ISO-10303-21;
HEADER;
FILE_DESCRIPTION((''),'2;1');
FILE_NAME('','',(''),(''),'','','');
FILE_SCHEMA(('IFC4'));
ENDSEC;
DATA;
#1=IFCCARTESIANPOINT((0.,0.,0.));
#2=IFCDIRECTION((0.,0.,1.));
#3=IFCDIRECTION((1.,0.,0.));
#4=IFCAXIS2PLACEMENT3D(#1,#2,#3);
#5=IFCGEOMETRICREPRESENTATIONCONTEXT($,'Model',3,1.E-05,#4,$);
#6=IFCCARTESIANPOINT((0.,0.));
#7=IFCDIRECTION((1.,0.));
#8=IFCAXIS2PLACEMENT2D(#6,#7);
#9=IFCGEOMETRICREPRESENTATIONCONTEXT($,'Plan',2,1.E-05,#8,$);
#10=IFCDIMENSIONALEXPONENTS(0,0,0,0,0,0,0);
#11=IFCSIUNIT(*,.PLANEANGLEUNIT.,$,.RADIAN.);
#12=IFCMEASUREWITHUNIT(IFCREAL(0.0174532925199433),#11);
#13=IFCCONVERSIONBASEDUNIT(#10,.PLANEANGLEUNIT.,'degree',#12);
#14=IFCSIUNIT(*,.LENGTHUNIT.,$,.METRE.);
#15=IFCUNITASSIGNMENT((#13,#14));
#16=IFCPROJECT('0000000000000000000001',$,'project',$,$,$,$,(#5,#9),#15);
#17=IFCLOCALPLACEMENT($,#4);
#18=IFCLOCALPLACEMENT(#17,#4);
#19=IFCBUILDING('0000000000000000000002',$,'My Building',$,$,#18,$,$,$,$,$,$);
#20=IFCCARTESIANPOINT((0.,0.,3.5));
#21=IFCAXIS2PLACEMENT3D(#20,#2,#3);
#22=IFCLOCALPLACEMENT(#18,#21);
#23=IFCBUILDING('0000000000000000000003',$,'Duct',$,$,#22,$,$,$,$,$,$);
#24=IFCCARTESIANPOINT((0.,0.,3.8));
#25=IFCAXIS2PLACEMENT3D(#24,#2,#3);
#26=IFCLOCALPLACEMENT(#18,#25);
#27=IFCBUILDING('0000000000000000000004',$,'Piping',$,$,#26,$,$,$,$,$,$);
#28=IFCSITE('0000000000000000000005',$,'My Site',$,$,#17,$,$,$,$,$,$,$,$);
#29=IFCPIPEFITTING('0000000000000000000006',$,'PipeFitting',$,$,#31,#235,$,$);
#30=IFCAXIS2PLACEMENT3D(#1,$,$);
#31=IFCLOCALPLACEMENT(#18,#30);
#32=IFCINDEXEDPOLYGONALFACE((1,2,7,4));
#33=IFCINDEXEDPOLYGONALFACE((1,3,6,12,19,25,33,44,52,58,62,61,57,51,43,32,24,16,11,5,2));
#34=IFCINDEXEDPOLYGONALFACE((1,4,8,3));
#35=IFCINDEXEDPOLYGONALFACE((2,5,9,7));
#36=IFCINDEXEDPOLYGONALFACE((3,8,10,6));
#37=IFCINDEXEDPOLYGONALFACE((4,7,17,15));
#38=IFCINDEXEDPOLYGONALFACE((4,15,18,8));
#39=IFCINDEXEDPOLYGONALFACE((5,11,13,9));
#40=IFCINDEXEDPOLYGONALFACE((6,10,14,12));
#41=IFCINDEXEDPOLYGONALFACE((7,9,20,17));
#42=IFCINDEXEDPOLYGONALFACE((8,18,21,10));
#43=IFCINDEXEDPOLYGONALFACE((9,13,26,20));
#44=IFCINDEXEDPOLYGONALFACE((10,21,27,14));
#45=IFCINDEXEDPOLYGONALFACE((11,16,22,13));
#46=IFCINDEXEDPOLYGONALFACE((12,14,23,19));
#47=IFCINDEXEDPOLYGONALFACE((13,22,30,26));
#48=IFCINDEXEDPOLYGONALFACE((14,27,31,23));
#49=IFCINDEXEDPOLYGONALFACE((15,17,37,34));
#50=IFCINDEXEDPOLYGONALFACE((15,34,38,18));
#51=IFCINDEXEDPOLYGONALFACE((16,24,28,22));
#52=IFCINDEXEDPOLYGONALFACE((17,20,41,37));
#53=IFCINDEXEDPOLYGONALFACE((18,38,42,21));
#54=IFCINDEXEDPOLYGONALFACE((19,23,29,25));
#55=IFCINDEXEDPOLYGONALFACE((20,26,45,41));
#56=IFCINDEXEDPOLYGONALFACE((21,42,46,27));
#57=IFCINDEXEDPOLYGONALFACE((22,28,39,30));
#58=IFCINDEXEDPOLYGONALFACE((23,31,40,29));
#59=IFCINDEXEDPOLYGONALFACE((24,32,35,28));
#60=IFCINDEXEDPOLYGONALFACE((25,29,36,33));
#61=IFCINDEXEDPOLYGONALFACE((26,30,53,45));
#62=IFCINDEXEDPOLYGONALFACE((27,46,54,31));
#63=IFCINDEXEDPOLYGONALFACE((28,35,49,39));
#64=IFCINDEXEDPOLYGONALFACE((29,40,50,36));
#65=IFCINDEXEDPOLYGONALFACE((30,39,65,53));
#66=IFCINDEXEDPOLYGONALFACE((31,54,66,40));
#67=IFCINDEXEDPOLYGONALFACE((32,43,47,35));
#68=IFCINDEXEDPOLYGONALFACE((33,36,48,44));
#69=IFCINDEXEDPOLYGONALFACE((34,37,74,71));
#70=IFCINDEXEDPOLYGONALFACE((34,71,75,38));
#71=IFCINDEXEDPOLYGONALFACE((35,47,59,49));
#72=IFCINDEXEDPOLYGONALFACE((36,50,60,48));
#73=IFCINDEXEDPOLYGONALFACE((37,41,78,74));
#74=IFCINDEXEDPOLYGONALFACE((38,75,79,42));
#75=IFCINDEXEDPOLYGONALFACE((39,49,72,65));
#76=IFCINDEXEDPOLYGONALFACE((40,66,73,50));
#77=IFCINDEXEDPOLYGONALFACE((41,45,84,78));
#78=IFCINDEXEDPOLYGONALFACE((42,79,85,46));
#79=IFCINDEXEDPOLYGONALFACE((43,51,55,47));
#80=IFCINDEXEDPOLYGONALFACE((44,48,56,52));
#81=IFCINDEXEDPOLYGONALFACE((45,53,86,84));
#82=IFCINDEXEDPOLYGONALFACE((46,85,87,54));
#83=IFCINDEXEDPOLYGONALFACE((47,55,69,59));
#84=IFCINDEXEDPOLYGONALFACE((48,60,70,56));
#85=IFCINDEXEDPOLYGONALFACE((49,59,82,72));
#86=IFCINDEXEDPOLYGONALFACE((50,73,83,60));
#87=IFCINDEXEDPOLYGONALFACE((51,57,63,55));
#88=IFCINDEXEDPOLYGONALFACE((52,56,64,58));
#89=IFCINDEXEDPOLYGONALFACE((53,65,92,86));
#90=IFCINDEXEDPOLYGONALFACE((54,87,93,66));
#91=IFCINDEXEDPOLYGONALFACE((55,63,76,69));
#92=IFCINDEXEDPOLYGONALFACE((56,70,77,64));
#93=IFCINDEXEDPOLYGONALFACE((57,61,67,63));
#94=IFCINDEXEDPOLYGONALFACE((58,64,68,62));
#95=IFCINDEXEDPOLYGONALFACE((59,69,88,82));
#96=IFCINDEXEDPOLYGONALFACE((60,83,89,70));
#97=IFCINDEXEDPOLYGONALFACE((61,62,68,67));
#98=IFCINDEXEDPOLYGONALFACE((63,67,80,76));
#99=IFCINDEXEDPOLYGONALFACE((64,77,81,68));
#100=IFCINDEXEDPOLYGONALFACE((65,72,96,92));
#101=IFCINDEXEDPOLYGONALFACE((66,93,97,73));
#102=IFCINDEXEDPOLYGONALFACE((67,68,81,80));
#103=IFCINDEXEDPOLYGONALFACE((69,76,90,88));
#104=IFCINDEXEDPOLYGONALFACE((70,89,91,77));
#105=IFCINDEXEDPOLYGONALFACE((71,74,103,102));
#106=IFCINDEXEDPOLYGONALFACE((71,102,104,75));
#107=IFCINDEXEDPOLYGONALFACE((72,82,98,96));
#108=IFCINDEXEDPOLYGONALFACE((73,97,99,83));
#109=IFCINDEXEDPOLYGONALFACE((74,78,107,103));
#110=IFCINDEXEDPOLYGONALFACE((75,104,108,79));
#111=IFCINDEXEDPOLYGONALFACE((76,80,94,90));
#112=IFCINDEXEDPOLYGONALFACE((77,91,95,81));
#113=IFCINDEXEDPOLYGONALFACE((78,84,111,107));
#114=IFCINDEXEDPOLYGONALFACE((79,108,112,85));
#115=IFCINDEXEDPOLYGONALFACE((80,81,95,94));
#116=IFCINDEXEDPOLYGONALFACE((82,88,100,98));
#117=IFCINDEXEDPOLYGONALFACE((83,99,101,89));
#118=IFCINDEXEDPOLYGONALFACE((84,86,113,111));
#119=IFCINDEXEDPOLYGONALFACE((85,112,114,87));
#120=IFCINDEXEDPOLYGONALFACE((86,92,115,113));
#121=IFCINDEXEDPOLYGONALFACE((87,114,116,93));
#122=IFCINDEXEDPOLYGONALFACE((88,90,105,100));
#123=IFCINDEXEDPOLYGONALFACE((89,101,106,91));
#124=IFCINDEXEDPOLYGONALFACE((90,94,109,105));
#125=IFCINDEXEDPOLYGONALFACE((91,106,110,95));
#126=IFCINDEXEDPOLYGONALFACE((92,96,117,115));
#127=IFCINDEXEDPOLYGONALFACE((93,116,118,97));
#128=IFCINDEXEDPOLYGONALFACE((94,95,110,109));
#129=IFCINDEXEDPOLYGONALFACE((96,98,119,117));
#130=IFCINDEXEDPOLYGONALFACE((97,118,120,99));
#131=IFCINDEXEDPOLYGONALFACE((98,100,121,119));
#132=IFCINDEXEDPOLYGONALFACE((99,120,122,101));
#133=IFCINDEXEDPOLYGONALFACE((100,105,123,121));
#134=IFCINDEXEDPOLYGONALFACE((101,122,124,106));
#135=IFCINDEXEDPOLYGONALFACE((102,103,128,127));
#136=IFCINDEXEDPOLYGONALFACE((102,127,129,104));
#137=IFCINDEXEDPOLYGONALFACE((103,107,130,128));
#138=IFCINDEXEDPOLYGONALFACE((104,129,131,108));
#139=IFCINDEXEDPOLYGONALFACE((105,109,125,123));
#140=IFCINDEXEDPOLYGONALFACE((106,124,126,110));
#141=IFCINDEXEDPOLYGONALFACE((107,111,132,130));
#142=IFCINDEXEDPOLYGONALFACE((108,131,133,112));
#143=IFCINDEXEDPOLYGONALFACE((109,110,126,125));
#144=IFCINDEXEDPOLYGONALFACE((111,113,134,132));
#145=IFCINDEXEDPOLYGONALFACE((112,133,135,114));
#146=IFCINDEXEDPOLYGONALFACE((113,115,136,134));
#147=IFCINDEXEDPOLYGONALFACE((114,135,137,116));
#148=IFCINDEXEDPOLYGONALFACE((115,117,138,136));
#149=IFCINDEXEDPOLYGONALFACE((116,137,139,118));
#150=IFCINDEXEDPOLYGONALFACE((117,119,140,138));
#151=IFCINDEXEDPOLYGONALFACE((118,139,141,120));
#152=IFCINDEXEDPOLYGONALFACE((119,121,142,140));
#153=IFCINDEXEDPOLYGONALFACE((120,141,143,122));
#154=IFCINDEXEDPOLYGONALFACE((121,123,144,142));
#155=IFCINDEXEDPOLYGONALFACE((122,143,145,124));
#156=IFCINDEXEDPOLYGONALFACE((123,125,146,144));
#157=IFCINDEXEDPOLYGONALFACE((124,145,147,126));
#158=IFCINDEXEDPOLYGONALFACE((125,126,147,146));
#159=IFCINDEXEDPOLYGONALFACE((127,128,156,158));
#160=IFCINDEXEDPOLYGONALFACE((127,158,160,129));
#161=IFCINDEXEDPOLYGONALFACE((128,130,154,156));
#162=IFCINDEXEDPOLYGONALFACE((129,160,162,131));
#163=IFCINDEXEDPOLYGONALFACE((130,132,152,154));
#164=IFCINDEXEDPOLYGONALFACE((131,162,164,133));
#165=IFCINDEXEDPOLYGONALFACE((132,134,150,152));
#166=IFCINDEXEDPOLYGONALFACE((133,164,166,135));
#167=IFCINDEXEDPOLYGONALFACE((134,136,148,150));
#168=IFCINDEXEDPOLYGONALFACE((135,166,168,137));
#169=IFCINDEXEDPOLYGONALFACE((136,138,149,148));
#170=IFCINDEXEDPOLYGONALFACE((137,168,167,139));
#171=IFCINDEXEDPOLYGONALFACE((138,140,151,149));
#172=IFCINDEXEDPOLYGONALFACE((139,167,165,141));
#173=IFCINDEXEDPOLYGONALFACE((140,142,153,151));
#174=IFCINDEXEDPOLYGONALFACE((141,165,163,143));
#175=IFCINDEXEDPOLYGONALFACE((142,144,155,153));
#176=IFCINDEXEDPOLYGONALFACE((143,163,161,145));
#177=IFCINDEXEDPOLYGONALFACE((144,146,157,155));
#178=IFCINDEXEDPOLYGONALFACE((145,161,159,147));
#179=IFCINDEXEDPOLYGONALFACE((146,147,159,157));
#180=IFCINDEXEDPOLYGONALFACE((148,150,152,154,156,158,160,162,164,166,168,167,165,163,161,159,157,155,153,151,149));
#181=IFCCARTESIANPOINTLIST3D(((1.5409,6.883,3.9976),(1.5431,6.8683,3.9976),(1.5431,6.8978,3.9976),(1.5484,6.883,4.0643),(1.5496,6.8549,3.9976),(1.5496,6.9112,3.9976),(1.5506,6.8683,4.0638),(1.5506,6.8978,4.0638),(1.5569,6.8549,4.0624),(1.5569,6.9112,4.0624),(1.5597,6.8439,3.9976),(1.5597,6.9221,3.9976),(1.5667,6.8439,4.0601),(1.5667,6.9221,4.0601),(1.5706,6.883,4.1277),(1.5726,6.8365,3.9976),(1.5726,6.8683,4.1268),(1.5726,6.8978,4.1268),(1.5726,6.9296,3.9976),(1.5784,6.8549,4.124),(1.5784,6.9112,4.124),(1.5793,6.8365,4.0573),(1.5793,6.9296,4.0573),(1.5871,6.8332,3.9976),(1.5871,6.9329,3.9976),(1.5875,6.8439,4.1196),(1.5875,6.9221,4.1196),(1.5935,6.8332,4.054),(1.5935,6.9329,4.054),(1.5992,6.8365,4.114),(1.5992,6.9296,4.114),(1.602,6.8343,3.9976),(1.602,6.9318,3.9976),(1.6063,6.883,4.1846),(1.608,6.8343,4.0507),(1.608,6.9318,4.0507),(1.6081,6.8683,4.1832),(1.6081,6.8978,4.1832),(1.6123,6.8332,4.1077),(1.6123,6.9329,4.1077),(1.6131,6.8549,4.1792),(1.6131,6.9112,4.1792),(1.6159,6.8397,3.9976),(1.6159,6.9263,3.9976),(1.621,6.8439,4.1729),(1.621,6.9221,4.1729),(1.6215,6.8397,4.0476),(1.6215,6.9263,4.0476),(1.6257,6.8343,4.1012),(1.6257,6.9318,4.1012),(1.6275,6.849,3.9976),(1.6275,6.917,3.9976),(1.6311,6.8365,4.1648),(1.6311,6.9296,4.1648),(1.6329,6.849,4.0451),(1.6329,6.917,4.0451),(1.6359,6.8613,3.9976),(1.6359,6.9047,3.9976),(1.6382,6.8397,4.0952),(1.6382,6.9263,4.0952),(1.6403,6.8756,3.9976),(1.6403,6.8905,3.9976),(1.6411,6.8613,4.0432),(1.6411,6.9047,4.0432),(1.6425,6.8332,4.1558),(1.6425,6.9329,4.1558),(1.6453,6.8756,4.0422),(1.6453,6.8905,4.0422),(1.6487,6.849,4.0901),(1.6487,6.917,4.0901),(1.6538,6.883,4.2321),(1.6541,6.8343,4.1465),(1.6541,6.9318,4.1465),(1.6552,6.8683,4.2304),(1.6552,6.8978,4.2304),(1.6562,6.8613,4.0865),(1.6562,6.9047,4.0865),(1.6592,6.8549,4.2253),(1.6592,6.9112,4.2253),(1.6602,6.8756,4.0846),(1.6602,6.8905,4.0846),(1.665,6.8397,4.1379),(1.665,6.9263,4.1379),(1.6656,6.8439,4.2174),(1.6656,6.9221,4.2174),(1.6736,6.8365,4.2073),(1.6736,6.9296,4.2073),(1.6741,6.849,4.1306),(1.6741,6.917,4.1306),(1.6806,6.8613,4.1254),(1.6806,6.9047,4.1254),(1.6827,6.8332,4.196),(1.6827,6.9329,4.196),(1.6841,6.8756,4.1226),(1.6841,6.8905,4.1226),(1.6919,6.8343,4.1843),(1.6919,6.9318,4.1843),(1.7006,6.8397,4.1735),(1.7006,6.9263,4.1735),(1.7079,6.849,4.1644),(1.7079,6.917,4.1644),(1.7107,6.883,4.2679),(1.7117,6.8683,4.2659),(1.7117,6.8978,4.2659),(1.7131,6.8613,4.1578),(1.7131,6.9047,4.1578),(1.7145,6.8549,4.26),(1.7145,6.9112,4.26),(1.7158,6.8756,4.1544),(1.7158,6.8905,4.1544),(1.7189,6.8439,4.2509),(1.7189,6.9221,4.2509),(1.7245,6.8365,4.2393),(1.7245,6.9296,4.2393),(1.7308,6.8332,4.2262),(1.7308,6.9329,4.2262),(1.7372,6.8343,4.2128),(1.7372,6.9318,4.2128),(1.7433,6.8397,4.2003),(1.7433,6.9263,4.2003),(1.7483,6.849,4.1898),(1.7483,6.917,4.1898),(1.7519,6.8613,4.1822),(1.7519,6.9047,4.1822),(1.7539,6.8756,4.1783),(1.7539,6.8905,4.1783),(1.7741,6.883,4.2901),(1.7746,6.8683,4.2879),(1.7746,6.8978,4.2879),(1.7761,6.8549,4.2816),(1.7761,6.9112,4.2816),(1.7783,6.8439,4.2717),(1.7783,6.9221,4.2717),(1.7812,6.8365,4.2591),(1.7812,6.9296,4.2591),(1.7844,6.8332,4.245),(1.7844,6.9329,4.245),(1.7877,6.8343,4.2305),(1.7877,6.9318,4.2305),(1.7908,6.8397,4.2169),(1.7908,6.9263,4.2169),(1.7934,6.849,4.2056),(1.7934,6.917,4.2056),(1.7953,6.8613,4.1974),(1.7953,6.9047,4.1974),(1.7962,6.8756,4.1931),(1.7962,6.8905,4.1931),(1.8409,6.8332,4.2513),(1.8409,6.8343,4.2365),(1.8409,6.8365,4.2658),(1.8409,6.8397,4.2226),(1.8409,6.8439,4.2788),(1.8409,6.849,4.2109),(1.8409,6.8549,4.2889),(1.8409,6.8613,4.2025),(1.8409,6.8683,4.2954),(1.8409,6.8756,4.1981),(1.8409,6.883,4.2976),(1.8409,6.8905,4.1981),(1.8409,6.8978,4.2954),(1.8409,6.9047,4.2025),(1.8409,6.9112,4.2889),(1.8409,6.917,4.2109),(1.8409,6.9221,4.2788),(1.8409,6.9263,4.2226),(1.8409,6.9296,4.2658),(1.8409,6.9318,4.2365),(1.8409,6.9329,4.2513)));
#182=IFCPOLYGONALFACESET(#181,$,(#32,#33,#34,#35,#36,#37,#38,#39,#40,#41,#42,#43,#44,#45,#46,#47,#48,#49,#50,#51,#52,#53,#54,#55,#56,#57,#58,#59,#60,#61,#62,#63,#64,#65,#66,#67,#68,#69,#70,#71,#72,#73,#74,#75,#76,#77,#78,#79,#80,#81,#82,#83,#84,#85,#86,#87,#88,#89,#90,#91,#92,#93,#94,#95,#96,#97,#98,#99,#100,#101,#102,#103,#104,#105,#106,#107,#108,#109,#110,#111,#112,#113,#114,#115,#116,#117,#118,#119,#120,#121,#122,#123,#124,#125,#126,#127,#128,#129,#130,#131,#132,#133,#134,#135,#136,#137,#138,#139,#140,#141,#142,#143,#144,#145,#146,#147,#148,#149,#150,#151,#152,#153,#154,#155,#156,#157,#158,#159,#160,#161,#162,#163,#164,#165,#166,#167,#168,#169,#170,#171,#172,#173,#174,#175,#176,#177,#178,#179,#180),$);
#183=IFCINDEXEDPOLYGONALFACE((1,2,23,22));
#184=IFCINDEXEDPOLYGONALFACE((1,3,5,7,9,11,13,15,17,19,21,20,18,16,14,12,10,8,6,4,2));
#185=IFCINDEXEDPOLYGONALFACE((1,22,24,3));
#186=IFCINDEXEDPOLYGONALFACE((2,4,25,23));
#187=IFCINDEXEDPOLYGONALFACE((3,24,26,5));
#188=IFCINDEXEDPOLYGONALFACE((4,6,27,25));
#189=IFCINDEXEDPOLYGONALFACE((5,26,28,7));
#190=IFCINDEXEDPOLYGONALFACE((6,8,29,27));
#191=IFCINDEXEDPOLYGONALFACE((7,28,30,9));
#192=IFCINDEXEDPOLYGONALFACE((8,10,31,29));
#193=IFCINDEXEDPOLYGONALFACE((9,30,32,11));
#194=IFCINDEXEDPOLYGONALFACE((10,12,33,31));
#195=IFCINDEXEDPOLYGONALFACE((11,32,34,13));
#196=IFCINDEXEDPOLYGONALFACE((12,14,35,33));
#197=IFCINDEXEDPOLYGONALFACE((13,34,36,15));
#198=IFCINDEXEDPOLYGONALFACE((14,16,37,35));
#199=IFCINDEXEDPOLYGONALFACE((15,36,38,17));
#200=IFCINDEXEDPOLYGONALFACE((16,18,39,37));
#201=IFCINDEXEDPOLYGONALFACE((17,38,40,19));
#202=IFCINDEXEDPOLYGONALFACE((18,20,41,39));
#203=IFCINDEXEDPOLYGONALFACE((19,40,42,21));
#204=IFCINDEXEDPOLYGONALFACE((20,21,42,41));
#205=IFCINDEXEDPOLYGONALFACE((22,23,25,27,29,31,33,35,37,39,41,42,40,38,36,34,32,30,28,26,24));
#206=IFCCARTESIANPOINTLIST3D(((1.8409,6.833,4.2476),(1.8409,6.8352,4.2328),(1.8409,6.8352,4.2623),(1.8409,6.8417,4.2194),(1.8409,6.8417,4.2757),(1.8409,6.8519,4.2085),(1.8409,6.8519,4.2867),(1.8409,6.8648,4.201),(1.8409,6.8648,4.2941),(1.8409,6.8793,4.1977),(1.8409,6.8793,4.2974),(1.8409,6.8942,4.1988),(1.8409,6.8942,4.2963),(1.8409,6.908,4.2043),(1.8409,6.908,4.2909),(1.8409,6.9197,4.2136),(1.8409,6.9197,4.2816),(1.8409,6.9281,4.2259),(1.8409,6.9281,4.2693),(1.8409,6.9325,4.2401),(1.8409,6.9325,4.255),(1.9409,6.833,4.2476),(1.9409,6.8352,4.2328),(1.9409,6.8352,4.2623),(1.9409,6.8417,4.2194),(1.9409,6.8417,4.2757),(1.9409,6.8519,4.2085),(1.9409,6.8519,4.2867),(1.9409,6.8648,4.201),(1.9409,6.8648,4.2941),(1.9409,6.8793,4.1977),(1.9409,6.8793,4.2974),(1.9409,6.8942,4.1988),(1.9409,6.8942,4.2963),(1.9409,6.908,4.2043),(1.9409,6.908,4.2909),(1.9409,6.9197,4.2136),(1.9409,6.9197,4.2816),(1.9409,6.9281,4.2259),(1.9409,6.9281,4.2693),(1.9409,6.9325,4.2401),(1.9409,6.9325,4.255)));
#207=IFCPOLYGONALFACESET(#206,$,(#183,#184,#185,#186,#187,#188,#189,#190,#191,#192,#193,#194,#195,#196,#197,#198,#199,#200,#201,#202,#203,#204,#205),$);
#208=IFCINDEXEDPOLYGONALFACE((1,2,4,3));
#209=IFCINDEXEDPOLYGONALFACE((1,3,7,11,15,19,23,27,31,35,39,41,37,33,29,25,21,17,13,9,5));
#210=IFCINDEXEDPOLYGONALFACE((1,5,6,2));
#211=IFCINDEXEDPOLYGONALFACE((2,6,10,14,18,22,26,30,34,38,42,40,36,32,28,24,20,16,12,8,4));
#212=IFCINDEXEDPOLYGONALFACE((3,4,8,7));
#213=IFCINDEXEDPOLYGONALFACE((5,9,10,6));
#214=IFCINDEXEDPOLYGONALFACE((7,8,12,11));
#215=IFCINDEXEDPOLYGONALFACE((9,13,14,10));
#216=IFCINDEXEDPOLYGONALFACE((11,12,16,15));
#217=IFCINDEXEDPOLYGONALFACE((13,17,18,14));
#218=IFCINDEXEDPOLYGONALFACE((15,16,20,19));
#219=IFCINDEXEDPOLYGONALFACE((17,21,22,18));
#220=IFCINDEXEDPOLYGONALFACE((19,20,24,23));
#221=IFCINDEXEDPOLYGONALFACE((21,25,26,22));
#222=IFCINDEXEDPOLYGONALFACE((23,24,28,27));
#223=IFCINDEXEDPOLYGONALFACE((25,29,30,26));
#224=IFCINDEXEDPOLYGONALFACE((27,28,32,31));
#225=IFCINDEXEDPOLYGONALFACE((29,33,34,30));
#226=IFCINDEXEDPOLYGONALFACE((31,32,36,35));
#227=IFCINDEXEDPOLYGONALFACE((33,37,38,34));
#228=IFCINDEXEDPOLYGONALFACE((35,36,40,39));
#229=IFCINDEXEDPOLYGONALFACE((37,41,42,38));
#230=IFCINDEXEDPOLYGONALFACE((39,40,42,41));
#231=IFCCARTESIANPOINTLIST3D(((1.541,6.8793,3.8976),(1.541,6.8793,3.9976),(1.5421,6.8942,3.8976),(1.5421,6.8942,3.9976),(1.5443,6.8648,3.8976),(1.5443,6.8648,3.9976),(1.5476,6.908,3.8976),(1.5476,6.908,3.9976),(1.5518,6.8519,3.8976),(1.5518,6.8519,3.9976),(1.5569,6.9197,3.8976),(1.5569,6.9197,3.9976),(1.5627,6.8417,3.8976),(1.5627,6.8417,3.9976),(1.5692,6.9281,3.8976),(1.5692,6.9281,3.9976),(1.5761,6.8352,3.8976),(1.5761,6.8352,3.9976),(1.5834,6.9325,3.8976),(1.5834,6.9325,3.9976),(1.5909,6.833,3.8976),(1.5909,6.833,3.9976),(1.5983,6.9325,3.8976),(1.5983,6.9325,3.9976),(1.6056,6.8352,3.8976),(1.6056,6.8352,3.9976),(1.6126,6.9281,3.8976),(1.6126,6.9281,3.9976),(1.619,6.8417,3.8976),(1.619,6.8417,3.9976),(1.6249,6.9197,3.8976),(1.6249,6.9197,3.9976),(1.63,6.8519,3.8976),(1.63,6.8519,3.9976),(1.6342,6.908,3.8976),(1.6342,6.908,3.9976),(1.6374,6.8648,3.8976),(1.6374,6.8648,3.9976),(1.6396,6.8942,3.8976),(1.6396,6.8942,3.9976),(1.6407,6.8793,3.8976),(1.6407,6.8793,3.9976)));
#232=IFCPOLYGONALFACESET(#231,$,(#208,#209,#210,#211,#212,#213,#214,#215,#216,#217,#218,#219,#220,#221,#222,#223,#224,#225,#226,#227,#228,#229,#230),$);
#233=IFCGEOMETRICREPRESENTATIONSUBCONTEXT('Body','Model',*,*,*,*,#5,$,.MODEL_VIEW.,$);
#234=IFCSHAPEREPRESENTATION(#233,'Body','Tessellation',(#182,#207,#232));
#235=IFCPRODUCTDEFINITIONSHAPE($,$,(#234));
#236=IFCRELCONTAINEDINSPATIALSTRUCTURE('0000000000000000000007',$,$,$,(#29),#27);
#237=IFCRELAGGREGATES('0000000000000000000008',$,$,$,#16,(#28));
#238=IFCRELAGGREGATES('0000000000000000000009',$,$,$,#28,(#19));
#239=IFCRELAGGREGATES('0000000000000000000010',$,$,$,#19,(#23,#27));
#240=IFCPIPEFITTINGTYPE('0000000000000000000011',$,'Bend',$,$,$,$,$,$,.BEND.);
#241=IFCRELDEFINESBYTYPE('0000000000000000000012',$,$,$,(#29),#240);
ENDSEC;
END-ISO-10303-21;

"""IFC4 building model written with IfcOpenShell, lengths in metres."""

from ifc_helpers import new_model, entity, si_unit, converted_unit, frame, origin_with_axes, origin_2d_with_axis, place, context, subcontext, project, spatial, circle, extrude, source, transform, mapped, type_object, type_shapes, element, save


model = new_model("IFC4")

# Units and contexts
model_context = context("Model", 3, precision=1e-05, world=origin_with_axes())
plan_context = context("Plan", 2, precision=1e-05, world=origin_2d_with_axis())
body_context = subcontext(model_context, "Body", "Model", "MODEL_VIEW")
ifc_project = project(units=[converted_unit("PLANEANGLEUNIT", "degree", entity("IfcReal", 0.0174532925199433), si_unit("PLANEANGLEUNIT", "RADIAN"), dimensions=[0, 0, 0, 0, 0, 0, 0]), si_unit("LENGTHUNIT", "METRE")], contexts=[model_context, plan_context])

# Site, building
site_placement = place(None, origin_with_axes())
site = spatial("IfcSite", under=ifc_project, at=site_placement, Name="My Site")
building_1_placement = place(site_placement, origin_with_axes())
building_1 = spatial("IfcBuilding", under=site, at=building_1_placement, Name="My Building")

# Shared definitions
building_2_placement = place(building_1_placement, frame((0.0, 0.0, 3.5), z_axis=(0.0, 0.0, 1.0), x_axis=(1.0, 0.0, 0.0)))
building_2 = spatial("IfcBuilding", under=building_1, at=building_2_placement, Name="Duct")

# Shared definitions
building_3_placement = place(building_1_placement, frame((0.0, 0.0, 3.8), z_axis=(0.0, 0.0, 1.0), x_axis=(1.0, 0.0, 0.0)))
building_3 = spatial("IfcBuilding", under=building_1, at=building_3_placement, Name="Piping")

# Pipe fitting
pipe_fitting_type_1 = type_object("IfcPipeFittingType", Name="Bend", PredefinedType="BEND")
shared_shape = source(origin_with_axes(), body_context, "Body", "SolidModel", [
    entity("IfcSweptDiskSolid", entity("IfcIndexedPolyCurve", entity("IfcCartesianPointList3D", [[0.0, 0.0, 0.1], [0.0, -0.0732, 0.2768], [0.0, -0.25, 0.35]]), [entity("IfcArcIndex", [1, 2, 3])]), 0.05),
    extrude(circle(Radius=0.05), origin_with_axes(), (0.0, 0.0, 1.0), 0.1),
    extrude(circle(Radius=0.05), frame((0.0, -0.25, 0.35), z_axis=(0.0, -1.0, -0.000001), x_axis=(1.0, 0.0, 0.0)), (0.0, 0.0, 1.0), 0.1),
])
type_shapes(pipe_fitting_type_1, [shared_shape])
for number, where, z_axis, x_axis, name in (
    (1, (1.9409, 6.883, 0.4476), (-1.0, 0.000001, -0.000001), (-0.000001, -1.0, 0.0), "PipeFitting"),
):
    element("IfcPipeFitting", number, at=place(building_3_placement, frame(where, z_axis=z_axis, x_axis=x_axis)), inside=building_3, type_object=pipe_fitting_type_1, Name=name, context=body_context, shape_type="MappedRepresentation", body=[
        mapped(shared_shape, transform((0.0, 0.0, 0.0), x_axis=(1.0, 0.0, 0.0), y_axis=(0.0, 1.0, 0.0), z_axis=(0.0, 0.0, 1.0), scale=1.0)),
    ])

save(model, "model.ifc")
